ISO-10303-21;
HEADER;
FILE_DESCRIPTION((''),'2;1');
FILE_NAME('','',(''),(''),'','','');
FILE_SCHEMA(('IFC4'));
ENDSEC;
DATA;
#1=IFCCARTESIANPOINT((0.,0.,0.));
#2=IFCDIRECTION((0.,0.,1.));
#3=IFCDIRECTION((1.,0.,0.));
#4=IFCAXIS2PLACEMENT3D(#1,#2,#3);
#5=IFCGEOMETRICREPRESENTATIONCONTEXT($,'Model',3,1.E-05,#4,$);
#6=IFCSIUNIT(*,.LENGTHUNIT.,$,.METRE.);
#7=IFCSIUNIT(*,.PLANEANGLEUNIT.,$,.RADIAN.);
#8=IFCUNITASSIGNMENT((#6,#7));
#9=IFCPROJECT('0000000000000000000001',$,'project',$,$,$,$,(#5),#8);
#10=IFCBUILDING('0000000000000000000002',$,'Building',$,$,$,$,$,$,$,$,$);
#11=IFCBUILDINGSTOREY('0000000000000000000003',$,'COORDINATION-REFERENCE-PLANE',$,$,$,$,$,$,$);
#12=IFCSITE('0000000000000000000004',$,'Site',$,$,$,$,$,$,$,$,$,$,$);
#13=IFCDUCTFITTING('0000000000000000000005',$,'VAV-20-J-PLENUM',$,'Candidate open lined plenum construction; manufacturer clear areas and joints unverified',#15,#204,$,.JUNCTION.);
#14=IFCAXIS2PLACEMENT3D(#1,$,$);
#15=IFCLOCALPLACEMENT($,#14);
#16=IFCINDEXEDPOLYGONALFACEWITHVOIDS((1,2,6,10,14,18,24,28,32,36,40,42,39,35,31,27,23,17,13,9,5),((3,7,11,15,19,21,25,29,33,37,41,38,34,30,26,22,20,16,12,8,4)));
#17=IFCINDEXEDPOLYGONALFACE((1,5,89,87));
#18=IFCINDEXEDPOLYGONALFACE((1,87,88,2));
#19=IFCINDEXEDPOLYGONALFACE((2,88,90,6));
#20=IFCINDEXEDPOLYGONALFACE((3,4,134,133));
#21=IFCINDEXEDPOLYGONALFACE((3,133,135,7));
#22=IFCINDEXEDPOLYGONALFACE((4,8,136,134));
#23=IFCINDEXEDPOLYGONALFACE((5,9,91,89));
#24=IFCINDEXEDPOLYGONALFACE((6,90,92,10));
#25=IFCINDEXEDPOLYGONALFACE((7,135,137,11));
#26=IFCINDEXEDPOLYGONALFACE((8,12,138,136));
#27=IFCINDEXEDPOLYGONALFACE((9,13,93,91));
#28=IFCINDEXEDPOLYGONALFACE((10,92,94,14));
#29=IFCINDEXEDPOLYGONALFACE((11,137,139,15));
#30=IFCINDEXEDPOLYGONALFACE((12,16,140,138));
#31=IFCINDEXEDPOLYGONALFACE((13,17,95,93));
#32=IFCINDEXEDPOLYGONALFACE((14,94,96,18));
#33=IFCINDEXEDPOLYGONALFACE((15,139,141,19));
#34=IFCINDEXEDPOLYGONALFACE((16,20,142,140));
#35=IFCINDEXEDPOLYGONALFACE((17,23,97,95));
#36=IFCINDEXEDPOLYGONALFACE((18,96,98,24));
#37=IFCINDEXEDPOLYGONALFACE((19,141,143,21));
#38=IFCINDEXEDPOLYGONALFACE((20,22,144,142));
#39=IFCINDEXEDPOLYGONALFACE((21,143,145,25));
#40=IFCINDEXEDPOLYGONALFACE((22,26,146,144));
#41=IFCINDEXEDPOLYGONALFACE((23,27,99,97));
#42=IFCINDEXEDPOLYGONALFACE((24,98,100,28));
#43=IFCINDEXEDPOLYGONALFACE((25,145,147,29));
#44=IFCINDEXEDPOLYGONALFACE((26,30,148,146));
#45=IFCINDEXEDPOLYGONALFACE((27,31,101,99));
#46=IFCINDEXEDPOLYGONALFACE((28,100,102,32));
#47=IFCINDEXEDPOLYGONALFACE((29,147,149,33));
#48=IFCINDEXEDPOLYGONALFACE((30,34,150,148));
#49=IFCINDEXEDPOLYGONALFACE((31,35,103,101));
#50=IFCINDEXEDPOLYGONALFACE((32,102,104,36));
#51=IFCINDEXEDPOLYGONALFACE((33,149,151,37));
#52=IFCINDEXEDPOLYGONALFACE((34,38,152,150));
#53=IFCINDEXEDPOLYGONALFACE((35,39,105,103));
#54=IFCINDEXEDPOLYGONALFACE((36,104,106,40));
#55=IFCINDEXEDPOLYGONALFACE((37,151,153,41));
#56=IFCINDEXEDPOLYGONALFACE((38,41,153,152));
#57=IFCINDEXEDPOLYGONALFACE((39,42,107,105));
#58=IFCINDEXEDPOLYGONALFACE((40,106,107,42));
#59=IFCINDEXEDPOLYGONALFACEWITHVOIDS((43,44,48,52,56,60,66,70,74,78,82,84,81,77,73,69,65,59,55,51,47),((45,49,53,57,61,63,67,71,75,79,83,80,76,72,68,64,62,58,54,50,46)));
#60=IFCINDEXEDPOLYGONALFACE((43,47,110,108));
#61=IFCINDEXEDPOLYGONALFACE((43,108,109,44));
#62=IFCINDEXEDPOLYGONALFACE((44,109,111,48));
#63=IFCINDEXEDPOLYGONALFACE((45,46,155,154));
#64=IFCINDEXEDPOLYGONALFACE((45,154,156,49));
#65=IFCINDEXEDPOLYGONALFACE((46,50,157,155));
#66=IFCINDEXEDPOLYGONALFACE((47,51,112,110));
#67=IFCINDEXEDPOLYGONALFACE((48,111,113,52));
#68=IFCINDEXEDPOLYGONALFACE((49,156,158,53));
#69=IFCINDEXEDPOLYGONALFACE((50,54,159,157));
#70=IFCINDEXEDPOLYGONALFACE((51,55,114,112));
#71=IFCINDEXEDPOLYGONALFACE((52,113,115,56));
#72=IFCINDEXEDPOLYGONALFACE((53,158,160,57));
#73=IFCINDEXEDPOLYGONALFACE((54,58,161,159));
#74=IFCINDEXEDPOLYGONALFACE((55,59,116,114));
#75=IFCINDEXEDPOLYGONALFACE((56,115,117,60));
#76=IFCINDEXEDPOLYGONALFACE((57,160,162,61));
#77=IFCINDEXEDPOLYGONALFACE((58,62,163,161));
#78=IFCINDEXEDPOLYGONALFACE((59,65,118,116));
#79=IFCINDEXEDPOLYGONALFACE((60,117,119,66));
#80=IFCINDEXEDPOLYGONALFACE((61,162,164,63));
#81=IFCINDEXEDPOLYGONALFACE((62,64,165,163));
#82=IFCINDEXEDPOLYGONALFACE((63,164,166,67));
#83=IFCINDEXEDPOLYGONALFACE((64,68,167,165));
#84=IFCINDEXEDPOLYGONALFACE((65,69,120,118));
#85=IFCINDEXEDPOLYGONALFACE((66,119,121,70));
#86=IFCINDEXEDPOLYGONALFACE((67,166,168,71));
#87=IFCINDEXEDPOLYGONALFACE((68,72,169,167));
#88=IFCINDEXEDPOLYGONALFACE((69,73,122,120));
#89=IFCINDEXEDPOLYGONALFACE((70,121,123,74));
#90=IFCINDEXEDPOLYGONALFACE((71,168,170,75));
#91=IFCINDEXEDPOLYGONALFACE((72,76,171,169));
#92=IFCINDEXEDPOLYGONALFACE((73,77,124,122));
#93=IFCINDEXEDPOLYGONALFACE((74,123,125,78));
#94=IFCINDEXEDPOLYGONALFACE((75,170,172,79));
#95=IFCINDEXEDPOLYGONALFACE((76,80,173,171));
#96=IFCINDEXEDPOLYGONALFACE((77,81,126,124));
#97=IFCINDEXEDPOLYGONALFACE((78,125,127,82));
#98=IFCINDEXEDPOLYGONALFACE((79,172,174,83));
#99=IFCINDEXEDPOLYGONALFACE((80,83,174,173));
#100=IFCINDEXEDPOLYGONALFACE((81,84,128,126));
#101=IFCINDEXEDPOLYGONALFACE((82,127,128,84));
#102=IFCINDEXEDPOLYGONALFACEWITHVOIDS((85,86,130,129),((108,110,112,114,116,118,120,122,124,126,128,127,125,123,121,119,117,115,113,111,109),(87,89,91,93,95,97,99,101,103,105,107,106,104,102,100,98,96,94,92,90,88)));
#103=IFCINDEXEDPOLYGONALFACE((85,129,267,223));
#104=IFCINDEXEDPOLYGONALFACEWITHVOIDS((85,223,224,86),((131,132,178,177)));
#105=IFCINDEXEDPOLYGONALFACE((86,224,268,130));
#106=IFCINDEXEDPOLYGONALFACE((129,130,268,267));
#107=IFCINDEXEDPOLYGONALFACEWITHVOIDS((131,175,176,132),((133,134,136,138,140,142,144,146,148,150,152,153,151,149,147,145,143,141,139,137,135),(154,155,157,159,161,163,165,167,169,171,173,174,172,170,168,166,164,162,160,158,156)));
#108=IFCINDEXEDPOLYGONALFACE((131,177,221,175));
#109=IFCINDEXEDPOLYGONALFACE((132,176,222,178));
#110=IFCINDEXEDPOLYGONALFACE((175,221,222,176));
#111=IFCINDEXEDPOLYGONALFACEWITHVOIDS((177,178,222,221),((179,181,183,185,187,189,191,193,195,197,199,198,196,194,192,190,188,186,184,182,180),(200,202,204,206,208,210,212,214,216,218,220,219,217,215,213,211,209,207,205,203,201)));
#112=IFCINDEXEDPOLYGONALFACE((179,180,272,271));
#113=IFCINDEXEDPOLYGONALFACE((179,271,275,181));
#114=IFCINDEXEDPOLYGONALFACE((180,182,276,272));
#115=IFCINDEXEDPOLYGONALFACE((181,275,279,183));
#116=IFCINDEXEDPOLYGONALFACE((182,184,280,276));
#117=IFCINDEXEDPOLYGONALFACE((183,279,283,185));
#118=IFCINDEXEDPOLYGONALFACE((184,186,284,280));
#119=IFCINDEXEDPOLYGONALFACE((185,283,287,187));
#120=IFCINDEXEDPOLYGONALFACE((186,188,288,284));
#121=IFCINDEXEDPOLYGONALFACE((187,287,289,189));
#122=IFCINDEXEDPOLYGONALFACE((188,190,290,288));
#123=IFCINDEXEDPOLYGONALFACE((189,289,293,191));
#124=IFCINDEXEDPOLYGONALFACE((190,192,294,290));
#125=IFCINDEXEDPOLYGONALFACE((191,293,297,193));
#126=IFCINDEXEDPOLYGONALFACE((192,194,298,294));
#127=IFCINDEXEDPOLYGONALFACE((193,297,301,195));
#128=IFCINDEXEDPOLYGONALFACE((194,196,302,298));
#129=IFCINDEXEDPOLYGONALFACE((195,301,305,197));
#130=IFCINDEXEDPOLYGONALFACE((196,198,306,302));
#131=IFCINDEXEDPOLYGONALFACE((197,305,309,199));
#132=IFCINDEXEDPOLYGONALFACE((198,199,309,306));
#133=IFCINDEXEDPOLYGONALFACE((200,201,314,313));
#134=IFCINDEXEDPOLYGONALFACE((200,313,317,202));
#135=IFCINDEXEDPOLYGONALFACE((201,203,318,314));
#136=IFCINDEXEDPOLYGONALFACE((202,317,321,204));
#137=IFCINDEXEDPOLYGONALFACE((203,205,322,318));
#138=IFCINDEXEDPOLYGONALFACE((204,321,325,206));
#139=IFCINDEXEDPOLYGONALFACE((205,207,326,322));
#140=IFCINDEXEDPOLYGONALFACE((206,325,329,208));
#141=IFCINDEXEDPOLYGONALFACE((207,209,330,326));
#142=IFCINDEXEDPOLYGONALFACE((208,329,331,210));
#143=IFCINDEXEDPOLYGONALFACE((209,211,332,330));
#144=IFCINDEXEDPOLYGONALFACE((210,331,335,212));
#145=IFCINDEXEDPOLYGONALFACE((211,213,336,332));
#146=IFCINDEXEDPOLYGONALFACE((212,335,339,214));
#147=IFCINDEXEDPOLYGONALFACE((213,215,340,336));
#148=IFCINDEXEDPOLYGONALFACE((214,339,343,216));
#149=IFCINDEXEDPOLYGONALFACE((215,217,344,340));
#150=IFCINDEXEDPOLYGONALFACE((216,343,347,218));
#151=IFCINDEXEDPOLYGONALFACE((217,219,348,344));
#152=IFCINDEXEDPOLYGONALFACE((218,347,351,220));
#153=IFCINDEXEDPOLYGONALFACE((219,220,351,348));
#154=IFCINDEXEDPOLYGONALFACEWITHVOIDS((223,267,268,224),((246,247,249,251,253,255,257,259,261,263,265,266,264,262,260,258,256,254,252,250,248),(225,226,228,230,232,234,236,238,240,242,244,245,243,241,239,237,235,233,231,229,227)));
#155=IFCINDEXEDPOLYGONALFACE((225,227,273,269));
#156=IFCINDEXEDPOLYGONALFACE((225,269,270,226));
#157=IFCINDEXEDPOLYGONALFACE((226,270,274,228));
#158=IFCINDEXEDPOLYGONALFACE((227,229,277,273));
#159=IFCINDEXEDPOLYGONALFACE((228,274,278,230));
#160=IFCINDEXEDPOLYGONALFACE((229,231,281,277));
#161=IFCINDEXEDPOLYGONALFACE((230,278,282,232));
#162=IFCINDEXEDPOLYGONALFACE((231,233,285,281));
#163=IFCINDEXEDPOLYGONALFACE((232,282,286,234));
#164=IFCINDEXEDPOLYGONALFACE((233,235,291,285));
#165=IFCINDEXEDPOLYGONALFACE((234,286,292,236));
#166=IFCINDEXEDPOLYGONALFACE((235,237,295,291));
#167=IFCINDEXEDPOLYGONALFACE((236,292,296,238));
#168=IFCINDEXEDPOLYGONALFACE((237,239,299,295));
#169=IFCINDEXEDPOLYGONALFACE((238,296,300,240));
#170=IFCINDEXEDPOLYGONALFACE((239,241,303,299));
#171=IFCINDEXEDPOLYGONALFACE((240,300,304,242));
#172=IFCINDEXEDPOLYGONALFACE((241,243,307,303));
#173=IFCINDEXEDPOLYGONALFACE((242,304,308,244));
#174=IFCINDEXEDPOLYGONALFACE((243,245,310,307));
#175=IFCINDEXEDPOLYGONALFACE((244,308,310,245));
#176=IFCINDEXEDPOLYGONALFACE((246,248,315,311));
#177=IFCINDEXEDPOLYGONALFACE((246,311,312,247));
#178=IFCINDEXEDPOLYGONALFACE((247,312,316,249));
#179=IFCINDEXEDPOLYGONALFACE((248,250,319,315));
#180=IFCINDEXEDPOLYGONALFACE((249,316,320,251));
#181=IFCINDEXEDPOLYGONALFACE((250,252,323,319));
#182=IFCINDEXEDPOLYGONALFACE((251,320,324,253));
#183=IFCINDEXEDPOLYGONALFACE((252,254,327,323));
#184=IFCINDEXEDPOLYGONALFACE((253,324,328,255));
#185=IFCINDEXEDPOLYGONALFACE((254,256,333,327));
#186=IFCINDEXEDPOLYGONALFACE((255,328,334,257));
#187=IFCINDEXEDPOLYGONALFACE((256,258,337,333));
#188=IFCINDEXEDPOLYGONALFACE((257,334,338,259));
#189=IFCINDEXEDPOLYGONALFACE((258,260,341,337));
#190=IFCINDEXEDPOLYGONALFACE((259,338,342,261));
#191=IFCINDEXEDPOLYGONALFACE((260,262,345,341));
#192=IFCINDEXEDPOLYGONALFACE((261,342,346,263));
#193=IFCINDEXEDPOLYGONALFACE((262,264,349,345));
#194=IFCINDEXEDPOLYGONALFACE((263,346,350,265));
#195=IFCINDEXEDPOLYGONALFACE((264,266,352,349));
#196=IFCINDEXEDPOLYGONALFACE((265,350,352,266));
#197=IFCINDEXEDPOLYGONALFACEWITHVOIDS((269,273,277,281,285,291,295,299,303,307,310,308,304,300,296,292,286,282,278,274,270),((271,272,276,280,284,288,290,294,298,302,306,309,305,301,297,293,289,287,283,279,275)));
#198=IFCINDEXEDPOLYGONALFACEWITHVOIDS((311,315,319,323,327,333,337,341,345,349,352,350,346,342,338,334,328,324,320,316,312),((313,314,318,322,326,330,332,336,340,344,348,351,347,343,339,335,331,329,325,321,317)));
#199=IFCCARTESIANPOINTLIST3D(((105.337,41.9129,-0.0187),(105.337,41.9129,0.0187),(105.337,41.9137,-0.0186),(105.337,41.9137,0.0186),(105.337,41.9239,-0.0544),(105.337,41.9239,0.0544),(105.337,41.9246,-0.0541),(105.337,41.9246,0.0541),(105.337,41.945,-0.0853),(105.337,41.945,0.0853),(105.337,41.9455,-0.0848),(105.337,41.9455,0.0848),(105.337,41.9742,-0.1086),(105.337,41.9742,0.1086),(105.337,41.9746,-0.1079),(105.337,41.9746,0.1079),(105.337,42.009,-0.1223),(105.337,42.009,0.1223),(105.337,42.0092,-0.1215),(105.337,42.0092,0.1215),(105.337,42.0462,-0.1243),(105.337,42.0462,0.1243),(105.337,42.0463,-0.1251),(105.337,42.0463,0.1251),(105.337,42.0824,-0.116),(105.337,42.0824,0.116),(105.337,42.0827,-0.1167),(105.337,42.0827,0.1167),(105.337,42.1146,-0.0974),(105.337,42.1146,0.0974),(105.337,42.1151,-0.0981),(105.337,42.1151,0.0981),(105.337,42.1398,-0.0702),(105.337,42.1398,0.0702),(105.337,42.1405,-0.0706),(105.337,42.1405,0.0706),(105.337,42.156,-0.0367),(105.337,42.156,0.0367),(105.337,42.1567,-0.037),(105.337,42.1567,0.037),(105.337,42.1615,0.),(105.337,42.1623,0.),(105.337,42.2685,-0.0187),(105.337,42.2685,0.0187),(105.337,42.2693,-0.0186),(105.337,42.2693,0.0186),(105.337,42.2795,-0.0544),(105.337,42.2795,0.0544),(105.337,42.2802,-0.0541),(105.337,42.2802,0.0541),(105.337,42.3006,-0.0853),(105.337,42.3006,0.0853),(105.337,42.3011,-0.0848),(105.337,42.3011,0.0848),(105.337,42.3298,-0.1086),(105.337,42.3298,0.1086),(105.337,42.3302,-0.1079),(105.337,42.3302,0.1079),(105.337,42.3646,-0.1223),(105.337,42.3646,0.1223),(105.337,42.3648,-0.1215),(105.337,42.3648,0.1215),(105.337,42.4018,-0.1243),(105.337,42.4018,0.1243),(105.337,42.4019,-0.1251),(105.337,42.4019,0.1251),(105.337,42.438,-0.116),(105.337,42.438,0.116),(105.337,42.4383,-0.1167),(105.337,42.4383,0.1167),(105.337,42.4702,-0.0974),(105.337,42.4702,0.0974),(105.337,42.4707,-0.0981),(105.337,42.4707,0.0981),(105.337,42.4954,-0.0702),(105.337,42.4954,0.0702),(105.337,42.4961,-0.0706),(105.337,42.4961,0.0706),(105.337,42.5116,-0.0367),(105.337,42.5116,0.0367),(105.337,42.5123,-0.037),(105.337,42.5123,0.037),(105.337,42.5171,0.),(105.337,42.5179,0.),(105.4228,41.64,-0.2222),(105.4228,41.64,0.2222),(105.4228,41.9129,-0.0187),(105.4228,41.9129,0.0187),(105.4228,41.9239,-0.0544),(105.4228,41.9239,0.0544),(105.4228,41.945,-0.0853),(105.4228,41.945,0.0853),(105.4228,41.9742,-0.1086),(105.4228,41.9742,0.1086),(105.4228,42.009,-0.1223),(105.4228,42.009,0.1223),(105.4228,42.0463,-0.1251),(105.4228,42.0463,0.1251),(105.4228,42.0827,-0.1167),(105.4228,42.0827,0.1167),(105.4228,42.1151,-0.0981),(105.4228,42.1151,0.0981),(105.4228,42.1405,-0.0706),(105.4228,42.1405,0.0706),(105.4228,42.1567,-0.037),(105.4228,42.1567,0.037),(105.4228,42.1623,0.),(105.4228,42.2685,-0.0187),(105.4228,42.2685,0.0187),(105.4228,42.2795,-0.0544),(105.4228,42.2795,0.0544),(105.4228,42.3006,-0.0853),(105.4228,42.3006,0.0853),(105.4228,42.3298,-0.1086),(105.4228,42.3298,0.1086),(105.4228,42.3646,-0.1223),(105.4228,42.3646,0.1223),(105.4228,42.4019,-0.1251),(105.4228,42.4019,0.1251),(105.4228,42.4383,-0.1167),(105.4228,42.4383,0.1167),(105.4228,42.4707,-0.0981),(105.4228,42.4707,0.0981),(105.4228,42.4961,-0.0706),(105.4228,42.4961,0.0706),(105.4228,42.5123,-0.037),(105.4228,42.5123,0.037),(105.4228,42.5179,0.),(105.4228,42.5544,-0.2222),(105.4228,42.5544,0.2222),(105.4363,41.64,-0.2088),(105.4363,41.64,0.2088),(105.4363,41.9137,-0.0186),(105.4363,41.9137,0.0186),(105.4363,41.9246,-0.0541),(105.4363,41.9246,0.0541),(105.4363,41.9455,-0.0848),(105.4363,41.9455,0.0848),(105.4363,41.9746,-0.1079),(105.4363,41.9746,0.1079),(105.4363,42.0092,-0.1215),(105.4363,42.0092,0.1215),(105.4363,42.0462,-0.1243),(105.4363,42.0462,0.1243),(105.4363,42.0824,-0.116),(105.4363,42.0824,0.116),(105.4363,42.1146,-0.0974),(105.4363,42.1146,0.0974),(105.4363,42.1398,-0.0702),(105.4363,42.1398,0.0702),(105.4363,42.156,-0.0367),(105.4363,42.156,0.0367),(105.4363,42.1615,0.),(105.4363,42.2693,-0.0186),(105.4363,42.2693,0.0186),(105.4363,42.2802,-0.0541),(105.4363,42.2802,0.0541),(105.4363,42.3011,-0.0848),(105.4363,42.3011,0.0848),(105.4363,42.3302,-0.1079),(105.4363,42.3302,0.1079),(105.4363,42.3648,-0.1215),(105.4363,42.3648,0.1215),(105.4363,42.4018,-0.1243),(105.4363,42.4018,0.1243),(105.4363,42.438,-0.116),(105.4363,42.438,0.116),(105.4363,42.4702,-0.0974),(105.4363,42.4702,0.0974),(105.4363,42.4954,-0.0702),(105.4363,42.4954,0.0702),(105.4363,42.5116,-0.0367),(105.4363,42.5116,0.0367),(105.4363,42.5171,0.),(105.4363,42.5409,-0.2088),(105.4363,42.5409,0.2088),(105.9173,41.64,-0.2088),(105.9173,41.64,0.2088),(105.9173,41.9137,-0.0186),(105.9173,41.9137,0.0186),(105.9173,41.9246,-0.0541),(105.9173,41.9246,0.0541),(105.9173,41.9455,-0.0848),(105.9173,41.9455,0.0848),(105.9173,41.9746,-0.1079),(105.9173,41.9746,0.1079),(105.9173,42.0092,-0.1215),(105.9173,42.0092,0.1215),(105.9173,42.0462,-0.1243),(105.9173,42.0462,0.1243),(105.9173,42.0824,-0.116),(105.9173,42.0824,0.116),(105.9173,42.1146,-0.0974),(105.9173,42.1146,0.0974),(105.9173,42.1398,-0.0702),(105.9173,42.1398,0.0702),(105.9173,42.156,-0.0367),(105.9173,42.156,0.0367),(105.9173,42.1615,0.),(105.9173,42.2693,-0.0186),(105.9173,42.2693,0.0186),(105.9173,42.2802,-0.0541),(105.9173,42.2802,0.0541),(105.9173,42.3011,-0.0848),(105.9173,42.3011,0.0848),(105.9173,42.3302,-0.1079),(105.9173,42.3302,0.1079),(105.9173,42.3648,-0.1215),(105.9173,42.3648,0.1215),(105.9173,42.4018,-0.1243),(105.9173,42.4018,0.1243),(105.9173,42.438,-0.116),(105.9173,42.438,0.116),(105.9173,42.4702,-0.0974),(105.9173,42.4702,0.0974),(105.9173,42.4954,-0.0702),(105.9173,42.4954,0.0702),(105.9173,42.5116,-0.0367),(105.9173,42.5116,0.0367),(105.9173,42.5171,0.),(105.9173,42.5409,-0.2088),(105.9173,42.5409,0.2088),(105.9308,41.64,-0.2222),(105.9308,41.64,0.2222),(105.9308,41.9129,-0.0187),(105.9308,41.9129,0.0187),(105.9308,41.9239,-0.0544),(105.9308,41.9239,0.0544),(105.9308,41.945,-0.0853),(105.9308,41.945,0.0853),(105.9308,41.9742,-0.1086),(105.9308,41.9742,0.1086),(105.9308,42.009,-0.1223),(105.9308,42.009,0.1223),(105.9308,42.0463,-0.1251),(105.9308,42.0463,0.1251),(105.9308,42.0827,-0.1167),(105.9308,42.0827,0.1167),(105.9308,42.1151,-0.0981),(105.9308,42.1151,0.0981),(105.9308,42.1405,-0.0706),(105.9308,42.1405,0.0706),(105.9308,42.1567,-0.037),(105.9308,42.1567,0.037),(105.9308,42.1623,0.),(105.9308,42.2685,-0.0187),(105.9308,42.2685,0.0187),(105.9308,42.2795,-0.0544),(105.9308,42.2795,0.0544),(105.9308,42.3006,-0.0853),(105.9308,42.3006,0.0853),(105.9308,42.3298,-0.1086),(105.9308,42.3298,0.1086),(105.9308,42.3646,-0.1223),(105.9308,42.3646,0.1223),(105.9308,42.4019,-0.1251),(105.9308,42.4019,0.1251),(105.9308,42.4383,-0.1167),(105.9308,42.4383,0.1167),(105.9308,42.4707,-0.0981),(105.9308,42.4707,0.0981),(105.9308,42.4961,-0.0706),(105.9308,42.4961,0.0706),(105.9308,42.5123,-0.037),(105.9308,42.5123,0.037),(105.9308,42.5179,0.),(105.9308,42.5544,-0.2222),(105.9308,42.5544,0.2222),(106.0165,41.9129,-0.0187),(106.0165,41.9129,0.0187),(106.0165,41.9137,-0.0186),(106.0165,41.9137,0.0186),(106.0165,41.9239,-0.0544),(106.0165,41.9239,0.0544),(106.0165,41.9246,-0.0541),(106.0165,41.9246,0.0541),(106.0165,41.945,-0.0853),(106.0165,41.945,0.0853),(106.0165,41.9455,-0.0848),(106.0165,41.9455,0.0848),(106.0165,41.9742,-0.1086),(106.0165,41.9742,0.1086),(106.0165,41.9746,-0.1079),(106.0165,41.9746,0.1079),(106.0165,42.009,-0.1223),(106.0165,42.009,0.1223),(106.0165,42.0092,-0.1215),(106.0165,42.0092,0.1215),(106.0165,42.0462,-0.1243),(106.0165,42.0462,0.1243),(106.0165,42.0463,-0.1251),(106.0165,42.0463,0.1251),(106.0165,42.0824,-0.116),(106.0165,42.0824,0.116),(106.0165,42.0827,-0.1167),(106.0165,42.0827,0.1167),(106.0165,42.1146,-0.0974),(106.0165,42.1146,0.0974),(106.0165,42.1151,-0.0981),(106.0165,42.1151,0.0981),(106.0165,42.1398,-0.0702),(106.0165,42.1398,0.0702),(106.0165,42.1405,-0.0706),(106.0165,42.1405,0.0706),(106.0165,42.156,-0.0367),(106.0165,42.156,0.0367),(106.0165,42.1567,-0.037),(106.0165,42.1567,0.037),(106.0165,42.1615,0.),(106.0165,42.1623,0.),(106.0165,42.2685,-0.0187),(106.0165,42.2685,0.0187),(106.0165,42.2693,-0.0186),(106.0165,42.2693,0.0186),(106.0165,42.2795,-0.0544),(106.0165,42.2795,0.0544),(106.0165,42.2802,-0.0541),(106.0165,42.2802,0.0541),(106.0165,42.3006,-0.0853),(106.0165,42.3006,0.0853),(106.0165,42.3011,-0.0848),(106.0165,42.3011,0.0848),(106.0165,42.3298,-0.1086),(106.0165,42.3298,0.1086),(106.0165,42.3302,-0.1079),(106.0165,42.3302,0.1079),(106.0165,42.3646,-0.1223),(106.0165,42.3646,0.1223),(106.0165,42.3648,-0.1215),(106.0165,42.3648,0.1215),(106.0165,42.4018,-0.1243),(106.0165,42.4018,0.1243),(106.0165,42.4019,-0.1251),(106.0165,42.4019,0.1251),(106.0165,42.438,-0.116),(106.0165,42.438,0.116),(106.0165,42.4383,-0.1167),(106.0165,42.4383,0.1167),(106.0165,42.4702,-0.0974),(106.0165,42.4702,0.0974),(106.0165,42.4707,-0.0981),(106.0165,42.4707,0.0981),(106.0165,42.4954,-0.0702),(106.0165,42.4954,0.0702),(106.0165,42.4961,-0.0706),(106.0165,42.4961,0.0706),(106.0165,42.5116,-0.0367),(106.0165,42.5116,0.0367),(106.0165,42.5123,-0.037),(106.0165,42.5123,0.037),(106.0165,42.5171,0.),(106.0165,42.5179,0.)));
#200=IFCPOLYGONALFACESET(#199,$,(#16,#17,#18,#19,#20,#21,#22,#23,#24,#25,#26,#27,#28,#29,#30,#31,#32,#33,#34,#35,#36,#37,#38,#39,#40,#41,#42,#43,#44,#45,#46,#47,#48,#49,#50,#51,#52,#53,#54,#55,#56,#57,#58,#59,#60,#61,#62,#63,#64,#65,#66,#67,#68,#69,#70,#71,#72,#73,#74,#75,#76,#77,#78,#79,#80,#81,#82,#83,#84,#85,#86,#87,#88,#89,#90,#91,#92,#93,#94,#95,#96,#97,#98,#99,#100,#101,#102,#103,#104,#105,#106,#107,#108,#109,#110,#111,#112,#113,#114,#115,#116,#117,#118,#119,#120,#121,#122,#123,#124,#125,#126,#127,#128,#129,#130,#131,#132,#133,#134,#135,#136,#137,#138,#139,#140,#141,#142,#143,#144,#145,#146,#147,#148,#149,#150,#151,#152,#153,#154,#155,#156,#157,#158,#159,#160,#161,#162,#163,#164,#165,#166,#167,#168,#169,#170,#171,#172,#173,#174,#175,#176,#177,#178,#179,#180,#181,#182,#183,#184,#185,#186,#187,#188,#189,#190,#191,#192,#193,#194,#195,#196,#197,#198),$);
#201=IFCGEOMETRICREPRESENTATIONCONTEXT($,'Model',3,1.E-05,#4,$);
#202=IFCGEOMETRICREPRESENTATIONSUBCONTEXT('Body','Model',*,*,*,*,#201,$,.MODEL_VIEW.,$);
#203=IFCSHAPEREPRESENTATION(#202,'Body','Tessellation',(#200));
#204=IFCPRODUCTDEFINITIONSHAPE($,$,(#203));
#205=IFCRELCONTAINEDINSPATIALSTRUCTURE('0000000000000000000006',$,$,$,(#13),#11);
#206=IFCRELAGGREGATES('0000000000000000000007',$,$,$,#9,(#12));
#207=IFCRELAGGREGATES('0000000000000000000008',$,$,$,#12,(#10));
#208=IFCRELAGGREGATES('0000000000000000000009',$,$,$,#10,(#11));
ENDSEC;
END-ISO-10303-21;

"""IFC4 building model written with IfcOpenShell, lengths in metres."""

from ifc_helpers import new_model, si_unit, frame, origin_with_axes, place, context, subcontext, project, spatial, rectangle, circle, extrude, boolean, element, save


model = new_model("IFC4")

# Units and contexts
model_context_1 = context("Model", 3, precision=1e-05, world=origin_with_axes())
model_context_2 = context("Model", 3, precision=1e-05, world=origin_with_axes())
body_context_1 = subcontext(model_context_2, "Body", "Model", "MODEL_VIEW")
ifc_project = project(units=[si_unit("LENGTHUNIT", "METRE"), si_unit("PLANEANGLEUNIT", "RADIAN")], contexts=[model_context_1])

# Site, building, storey
site = spatial("IfcSite", under=ifc_project, Name="Site")
building = spatial("IfcBuilding", under=site, Name="Building")
storey = spatial("IfcBuildingStorey", under=building, Name="COORDINATION-REFERENCE-PLANE")

# Duct fitting
duct_fitting_1_placement = place(None, frame((105.4228, 41.64, -0.2223), z_axis=(0.0, 0.0, 1.0), x_axis=(1.0, 0.0, 0.0)))
solid = boolean("UNION", boolean("UNION", boolean("UNION", boolean("UNION", extrude(rectangle(XDim=0.481, YDim=0.4175), frame((0.254, -0.01, 0.2223), z_axis=(0.0, 1.0, 0.0), x_axis=(-1.0, 0.0, 0.0)), (0.0, 0.0, 1.0), 0.9109), extrude(circle(Radius=0.1246), frame((0.4845, 0.3969, 0.2223), z_axis=(1.0, 0.0, 0.0), x_axis=(0.0, 1.0, 0.0)), (0.0, 0.0, 1.0), 0.1192)), extrude(circle(Radius=0.1246), frame((0.0235, 0.3969, 0.2223), z_axis=(-1.0, 0.0, 0.0), x_axis=(0.0, 1.0, 0.0)), (0.0, 0.0, 1.0), 0.1192)), extrude(circle(Radius=0.1246), frame((0.4845, 0.7525, 0.2223), z_axis=(1.0, 0.0, 0.0), x_axis=(0.0, 1.0, 0.0)), (0.0, 0.0, 1.0), 0.1192)), extrude(circle(Radius=0.1246), frame((0.0235, 0.7525, 0.2223), z_axis=(-1.0, 0.0, 0.0), x_axis=(0.0, 1.0, 0.0)), (0.0, 0.0, 1.0), 0.1192))
element("IfcDuctFitting", 1, at=duct_fitting_1_placement, inside=storey, Name="VAV-20-J-PLENUM", ObjectType="Candidate open lined plenum construction; manufacturer clear areas and joints unverified", PredefinedType="JUNCTION", context=body_context_1, shape_type="CSG", body=[
    boolean("DIFFERENCE", boolean("UNION", boolean("UNION", boolean("UNION", boolean("UNION", extrude(rectangle(XDim=0.508, YDim=0.4445), frame((0.254, 0.0, 0.2223), z_axis=(0.0, 1.0, 0.0), x_axis=(-1.0, 0.0, 0.0)), (0.0, 0.0, 1.0), 0.9144), extrude(circle(Radius=0.1254), frame((0.4845, 0.3969, 0.2223), z_axis=(1.0, 0.0, 0.0), x_axis=(0.0, 1.0, 0.0)), (0.0, 0.0, 1.0), 0.1092)), extrude(circle(Radius=0.1254), frame((0.0235, 0.3969, 0.2223), z_axis=(-1.0, 0.0, 0.0), x_axis=(0.0, 1.0, 0.0)), (0.0, 0.0, 1.0), 0.1092)), extrude(circle(Radius=0.1254), frame((0.4845, 0.7525, 0.2223), z_axis=(1.0, 0.0, 0.0), x_axis=(0.0, 1.0, 0.0)), (0.0, 0.0, 1.0), 0.1092)), extrude(circle(Radius=0.1254), frame((0.0235, 0.7525, 0.2223), z_axis=(-1.0, 0.0, 0.0), x_axis=(0.0, 1.0, 0.0)), (0.0, 0.0, 1.0), 0.1092)), solid),
])

save(model, "model.ifc")
